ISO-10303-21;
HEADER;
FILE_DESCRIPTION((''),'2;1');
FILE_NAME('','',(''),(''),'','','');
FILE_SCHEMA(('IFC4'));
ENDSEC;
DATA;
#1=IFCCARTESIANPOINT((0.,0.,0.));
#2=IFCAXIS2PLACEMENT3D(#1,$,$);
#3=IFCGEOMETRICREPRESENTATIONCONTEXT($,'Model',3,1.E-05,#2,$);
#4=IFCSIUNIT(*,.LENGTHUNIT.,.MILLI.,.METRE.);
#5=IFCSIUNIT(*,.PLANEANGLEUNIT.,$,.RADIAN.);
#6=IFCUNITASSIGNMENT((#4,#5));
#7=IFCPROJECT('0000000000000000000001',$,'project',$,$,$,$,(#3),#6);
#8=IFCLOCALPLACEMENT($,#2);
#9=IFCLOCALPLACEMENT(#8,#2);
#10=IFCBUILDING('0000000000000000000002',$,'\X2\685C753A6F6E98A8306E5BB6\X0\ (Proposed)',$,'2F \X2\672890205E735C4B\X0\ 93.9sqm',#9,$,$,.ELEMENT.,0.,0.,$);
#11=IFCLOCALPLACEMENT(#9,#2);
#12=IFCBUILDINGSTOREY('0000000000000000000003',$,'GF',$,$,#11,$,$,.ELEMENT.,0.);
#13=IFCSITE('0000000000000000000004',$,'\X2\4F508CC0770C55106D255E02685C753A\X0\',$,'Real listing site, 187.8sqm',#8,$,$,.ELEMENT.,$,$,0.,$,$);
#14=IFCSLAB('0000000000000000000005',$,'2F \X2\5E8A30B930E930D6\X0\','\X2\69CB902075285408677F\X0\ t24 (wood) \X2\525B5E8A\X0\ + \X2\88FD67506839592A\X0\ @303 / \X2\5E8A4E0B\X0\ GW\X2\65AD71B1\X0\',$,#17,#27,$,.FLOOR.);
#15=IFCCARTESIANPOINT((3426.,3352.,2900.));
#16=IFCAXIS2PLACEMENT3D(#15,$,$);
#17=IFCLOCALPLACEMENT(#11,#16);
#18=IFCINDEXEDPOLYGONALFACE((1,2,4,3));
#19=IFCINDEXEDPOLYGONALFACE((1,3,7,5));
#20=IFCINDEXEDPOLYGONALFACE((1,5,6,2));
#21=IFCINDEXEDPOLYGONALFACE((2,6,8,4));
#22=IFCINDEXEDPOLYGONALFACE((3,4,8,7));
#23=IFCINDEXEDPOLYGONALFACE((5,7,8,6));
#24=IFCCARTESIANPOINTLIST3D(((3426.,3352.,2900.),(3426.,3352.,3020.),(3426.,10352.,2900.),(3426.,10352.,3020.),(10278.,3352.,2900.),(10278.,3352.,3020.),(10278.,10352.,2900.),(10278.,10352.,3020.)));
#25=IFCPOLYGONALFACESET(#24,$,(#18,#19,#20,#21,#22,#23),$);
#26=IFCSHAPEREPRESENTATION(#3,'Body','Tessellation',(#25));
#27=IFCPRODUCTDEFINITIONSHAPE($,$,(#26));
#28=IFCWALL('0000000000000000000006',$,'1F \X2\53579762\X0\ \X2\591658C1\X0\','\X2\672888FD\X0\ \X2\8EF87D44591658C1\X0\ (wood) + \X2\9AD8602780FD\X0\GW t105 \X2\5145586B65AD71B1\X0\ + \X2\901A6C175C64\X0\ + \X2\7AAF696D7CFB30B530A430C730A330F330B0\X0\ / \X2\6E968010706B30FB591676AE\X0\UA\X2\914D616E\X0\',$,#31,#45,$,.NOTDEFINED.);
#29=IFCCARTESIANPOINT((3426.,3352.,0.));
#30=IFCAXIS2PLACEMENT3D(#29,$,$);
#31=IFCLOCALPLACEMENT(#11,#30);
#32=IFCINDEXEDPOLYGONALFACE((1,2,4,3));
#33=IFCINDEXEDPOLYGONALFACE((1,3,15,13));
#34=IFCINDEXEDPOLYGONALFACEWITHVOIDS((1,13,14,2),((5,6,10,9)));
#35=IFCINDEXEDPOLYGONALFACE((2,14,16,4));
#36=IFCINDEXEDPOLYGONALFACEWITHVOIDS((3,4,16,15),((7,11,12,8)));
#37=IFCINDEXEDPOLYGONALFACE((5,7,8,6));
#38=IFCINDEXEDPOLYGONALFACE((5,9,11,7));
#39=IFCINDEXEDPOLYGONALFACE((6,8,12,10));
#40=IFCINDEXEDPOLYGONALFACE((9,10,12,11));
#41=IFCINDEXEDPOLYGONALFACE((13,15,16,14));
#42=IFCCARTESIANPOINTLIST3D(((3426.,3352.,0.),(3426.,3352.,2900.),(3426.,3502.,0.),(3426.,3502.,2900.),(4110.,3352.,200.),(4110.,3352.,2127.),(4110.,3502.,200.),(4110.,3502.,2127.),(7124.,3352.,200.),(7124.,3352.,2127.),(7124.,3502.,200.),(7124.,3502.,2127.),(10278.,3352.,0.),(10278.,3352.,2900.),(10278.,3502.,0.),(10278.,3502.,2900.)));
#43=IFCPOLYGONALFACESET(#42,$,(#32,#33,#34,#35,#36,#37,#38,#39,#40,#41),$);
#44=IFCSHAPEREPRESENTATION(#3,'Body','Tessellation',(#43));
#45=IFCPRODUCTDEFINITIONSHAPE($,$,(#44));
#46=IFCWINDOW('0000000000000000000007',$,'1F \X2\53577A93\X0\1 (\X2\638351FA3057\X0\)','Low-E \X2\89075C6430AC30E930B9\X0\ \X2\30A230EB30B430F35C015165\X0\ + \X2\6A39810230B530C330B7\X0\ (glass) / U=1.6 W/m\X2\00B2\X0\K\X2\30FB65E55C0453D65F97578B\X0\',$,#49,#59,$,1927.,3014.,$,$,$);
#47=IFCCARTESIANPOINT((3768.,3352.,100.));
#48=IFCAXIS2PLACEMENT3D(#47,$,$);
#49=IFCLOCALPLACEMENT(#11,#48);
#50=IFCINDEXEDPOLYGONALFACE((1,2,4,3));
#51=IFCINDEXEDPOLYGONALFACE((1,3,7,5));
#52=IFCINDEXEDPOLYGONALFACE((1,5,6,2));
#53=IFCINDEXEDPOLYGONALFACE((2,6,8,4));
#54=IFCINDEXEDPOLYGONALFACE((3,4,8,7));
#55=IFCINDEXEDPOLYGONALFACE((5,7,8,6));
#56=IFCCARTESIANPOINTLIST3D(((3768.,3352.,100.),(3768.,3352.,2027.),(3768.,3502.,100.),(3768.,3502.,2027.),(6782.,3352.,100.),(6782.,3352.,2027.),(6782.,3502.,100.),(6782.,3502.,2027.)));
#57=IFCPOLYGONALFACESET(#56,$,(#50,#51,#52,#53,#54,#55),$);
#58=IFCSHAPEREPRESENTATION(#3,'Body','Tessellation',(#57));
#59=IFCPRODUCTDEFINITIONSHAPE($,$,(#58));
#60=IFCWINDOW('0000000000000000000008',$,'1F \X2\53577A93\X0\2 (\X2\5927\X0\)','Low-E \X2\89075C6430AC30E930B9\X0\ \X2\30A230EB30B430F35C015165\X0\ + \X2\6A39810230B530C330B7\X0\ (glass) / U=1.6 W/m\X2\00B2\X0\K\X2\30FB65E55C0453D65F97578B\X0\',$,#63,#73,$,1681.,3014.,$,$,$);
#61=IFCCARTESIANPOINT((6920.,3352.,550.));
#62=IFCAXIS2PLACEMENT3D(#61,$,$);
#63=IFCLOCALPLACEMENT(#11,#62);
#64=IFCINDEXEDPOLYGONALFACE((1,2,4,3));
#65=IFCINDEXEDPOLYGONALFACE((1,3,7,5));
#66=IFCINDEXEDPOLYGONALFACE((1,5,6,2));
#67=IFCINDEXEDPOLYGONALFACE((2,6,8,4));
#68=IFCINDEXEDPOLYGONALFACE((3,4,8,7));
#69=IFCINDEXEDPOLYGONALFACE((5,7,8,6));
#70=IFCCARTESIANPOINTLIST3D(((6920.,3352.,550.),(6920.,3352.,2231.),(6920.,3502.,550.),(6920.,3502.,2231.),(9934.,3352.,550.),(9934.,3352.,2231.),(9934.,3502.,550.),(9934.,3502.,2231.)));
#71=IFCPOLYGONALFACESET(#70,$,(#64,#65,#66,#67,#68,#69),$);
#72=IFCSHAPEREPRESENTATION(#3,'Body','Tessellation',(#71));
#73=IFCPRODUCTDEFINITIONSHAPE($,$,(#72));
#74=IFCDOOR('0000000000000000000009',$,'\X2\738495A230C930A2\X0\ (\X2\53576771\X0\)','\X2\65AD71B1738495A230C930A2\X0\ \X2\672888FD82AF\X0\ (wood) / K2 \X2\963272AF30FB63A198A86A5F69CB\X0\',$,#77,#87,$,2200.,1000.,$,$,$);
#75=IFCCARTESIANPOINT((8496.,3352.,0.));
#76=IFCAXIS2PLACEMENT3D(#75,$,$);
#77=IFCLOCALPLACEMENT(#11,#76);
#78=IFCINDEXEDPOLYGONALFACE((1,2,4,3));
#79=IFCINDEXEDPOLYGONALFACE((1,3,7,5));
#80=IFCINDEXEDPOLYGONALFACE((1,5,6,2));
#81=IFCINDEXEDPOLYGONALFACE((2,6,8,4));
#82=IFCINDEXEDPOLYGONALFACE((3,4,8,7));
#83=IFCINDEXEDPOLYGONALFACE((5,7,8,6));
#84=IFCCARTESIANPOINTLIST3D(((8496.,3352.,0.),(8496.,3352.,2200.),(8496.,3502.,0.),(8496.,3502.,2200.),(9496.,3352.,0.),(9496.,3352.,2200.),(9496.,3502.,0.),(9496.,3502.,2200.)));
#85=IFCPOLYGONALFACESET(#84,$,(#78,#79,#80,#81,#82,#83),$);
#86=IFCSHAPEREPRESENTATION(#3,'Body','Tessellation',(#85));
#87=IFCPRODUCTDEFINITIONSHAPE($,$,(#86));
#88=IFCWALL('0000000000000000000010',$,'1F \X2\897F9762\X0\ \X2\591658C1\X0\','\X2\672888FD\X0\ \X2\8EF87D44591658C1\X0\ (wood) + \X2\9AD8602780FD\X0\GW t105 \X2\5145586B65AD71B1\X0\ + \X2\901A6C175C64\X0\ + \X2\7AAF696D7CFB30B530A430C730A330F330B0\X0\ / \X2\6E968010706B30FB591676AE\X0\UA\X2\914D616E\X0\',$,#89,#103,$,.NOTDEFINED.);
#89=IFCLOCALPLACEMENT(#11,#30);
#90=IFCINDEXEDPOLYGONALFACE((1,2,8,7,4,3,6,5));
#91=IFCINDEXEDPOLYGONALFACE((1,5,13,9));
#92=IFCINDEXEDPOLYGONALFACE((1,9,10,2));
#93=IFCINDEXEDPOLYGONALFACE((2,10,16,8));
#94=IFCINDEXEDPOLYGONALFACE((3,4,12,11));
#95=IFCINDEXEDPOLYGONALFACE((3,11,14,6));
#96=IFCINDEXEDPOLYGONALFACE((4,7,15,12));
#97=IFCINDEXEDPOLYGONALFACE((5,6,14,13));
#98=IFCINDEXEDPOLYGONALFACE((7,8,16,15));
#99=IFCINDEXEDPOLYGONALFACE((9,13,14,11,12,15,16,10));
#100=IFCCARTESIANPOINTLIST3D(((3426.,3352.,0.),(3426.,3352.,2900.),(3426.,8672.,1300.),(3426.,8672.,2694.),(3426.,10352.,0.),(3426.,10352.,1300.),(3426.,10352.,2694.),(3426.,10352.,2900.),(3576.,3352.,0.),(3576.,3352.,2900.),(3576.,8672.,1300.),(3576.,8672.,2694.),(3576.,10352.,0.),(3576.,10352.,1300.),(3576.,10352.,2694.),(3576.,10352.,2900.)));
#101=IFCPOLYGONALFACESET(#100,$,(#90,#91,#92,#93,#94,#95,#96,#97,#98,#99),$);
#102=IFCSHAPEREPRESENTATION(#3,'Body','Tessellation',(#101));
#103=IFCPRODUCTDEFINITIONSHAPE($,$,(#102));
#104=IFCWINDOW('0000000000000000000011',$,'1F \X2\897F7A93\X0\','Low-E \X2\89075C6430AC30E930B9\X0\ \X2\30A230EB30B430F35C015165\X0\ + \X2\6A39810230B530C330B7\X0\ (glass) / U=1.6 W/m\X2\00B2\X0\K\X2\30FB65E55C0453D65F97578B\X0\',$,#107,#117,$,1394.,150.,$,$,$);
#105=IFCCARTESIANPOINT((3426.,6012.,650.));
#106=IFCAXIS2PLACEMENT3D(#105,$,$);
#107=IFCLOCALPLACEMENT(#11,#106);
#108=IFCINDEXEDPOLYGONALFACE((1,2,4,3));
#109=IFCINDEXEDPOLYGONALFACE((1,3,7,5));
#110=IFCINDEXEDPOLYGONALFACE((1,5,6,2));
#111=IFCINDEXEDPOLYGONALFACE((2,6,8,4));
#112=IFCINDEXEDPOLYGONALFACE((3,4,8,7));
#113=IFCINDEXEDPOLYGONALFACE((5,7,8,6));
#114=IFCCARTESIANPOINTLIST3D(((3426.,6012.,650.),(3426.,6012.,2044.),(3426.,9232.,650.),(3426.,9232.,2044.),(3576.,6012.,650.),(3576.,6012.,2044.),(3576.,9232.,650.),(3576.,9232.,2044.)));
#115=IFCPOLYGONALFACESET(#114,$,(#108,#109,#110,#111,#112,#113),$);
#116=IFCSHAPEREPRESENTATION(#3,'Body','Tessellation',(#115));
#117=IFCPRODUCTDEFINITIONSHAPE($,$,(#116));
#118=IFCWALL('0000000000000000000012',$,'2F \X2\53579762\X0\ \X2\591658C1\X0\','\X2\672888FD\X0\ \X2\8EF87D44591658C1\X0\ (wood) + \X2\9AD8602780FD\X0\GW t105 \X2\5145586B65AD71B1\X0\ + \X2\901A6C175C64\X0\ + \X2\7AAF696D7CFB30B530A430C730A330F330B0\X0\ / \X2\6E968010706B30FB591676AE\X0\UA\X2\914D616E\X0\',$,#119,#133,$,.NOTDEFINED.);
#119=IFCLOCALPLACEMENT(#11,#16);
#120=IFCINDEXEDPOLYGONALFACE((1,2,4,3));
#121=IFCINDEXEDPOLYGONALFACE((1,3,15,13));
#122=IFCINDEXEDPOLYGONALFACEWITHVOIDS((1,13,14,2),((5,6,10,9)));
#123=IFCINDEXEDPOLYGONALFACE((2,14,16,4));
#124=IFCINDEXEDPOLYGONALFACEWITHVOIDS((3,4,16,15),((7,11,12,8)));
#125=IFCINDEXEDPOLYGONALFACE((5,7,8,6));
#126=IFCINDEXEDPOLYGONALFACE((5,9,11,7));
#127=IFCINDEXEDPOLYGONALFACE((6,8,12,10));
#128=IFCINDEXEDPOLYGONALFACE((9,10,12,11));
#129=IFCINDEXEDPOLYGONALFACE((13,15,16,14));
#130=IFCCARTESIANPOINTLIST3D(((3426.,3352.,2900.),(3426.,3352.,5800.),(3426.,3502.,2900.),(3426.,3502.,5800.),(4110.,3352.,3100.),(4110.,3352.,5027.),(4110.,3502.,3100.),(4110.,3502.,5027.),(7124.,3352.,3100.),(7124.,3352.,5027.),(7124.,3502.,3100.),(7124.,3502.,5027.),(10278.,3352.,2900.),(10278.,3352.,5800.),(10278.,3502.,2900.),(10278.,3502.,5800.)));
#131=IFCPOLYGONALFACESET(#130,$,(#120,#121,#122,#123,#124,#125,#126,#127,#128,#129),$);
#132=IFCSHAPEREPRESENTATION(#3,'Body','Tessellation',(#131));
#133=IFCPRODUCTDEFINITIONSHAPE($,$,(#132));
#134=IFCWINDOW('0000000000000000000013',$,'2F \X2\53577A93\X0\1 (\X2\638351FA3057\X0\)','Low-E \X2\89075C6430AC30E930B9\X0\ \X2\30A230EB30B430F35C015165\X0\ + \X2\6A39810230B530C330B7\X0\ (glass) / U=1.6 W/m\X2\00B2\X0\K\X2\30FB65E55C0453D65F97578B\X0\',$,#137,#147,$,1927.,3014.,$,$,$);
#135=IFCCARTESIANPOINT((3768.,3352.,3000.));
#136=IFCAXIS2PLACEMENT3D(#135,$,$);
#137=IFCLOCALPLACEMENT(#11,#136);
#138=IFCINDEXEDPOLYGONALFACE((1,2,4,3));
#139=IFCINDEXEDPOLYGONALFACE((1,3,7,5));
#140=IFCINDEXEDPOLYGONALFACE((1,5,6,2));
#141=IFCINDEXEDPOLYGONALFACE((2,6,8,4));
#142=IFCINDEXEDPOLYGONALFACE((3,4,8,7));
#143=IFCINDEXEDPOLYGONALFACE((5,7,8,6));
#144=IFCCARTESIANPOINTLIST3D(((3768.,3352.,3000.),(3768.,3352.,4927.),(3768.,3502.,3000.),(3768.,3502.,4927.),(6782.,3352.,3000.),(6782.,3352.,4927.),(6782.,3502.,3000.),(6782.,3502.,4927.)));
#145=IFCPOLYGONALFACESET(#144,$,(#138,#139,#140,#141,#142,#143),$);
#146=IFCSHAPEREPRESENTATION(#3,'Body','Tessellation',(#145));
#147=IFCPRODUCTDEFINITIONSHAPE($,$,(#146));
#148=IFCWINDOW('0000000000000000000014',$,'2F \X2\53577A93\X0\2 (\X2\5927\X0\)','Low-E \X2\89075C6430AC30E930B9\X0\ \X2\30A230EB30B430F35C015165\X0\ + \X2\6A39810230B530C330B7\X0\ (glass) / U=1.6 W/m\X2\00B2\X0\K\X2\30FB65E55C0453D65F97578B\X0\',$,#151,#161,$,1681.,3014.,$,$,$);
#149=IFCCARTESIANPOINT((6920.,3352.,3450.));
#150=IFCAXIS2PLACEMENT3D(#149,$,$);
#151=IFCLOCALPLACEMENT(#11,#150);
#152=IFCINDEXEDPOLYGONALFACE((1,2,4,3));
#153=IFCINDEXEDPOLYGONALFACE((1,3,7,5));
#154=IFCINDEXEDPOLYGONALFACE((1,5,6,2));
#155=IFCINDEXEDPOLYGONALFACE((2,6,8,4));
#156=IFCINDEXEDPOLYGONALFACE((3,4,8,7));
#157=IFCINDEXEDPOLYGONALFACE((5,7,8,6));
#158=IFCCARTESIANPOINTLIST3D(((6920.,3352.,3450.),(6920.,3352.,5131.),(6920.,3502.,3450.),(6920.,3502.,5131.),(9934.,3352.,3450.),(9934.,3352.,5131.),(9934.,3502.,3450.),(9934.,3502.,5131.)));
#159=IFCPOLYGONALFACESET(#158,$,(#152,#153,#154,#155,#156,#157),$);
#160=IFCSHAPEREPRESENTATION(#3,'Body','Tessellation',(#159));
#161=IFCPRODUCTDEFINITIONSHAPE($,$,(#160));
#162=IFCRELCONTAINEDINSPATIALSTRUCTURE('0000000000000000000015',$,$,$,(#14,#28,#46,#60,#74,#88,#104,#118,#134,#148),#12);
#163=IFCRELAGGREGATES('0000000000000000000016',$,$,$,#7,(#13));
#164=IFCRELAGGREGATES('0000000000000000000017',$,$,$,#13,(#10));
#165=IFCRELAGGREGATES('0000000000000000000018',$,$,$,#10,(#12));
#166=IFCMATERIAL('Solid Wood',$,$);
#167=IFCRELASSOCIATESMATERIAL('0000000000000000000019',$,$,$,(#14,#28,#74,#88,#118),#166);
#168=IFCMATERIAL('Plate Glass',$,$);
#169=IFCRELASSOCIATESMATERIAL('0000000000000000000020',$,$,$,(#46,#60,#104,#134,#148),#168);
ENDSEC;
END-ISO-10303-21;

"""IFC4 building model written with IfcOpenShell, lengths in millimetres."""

from ifc_helpers import new_model, si_unit, frame, frame_2d, origin, place, context, project, spatial, rectangle, extrude, material, element, fill, save


model = new_model("IFC4")

# Units and contexts
model_context = context("Model", 3, precision=1e-05, world=origin())
ifc_project = project(units=[si_unit("LENGTHUNIT", "METRE", prefix="MILLI"), si_unit("PLANEANGLEUNIT", "RADIAN")], contexts=[model_context])

# Site, building, storey
site_placement = place(None, origin())
site = spatial("IfcSite", under=ifc_project, at=site_placement, Name="佐賀県唐津市桜町", ObjectType="Real listing site, 187.8sqm", CompositionType="ELEMENT", RefElevation=0.0)
building_placement = place(site_placement, origin())
building = spatial("IfcBuilding", under=site, at=building_placement, Name="桜町潮風の家 (Proposed)", ObjectType="2F 木造平屋 93.9sqm", CompositionType="ELEMENT", ElevationOfRefHeight=0.0, ElevationOfTerrain=0.0)
storey_placement = place(building_placement, origin())
storey = spatial("IfcBuildingStorey", under=building, at=storey_placement, Name="GF", CompositionType="ELEMENT", Elevation=0.0)

# Slab
ifc_material_1 = material(Name="Solid Wood")
slab_1_placement = place(storey_placement, frame((3426.0, 3352.0, 2900.0)))
element("IfcSlab", 1, at=slab_1_placement, inside=storey, material=ifc_material_1, Name="2F 床スラブ", Description="構造用合板 t24 (wood) 剛床 + 製材根太 @303 / 床下 GW断熱", PredefinedType="FLOOR", context=model_context, shape_type="SweptSolid", body=[
    extrude(rectangle(XDim=6852.0, YDim=7000.0, at=frame_2d((3426.0, 3500.0))), frame((3426.0, 3352.0, 2900.0)), (0.0, 0.0, 1.0), 120.0),
])

# Wall, openings, windows, door
wall_1_placement = place(storey_placement, frame((3426.0, 3352.0, 0.0)))
wall_1 = element("IfcWall", 2, at=wall_1_placement, inside=storey, material=ifc_material_1, Name="1F 南面 外壁", Description="木製 軸組外壁 (wood) + 高性能GW t105 充填断熱 + 通気層 + 窯業系サイディング / 準耐火・外皮UA配慮", PredefinedType="NOTDEFINED", context=model_context, shape_type="SweptSolid", body=[
    extrude(rectangle(XDim=6852.0, YDim=150.0, at=frame_2d((3426.0, 75.0))), frame((3426.0, 3352.0, 0.0)), (0.0, 0.0, 1.0), 2900.0),
])
opening_1_placement = place(storey_placement, frame((3768.0, 3352.0, 100.0)))
opening_1 = element("IfcOpeningElement", 3, at=opening_1_placement, cuts=wall_1, PredefinedType="NOTDEFINED", context=model_context, shape_type="SweptSolid", body=[
    extrude(rectangle(XDim=3014.0, YDim=150.0, at=frame_2d((1507.0, 75.0))), frame((3768.0, 3352.0, 100.0)), (0.0, 0.0, 1.0), 1927.0),
])
opening_2_placement = place(storey_placement, frame((6920.0, 3352.0, 550.0)))
opening_2 = element("IfcOpeningElement", 4, at=opening_2_placement, cuts=wall_1, PredefinedType="NOTDEFINED", context=model_context, shape_type="SweptSolid", body=[
    extrude(rectangle(XDim=3014.0, YDim=150.0, at=frame_2d((1507.0, 75.0))), frame((6920.0, 3352.0, 550.0)), (0.0, 0.0, 1.0), 1681.0),
])
opening_3_placement = place(storey_placement, frame((8496.0, 3352.0, 0.0)))
opening_3 = element("IfcOpeningElement", 5, at=opening_3_placement, cuts=wall_1, PredefinedType="NOTDEFINED", context=model_context, shape_type="SweptSolid", body=[
    extrude(rectangle(XDim=1000.0, YDim=150.0, at=frame_2d((500.0, 75.0))), frame((8496.0, 3352.0, 0.0)), (0.0, 0.0, 1.0), 2200.0),
])
ifc_material_2 = material(Name="Plate Glass")
window_1_placement = place(storey_placement, frame((3768.0, 3352.0, 100.0)))
window_1 = element("IfcWindow", 6, at=window_1_placement, inside=storey, material=ifc_material_2, Name="1F 南窓1 (掃出し)", Description="Low-E 複層ガラス アルゴン封入 + 樹脂サッシ (glass) / U=1.6 W/m²K・日射取得型", OverallHeight=1927.0, OverallWidth=3014.0, context=model_context, shape_type="SweptSolid", body=[
    extrude(rectangle(XDim=3014.0, YDim=150.0, at=frame_2d((1507.0, 75.0))), frame((3768.0, 3352.0, 100.0)), (0.0, 0.0, 1.0), 1927.0),
])
fill(opening_1, window_1)
window_2_placement = place(storey_placement, frame((6920.0, 3352.0, 550.0)))
window_2 = element("IfcWindow", 7, at=window_2_placement, inside=storey, material=ifc_material_2, Name="1F 南窓2 (大)", Description="Low-E 複層ガラス アルゴン封入 + 樹脂サッシ (glass) / U=1.6 W/m²K・日射取得型", OverallHeight=1681.0, OverallWidth=3014.0, context=model_context, shape_type="SweptSolid", body=[
    extrude(rectangle(XDim=3014.0, YDim=150.0, at=frame_2d((1507.0, 75.0))), frame((6920.0, 3352.0, 550.0)), (0.0, 0.0, 1.0), 1681.0),
])
fill(opening_2, window_2)
door_placement = place(storey_placement, frame((8496.0, 3352.0, 0.0)))
door = element("IfcDoor", 8, at=door_placement, inside=storey, material=ifc_material_1, Name="玄関ドア (南東)", Description="断熱玄関ドア 木製芯 (wood) / K2 防犯・採風機構", OverallHeight=2200.0, OverallWidth=1000.0, context=model_context, shape_type="SweptSolid", body=[
    extrude(rectangle(XDim=1000.0, YDim=150.0, at=frame_2d((500.0, 75.0))), frame((8496.0, 3352.0, 0.0)), (0.0, 0.0, 1.0), 2200.0),
])
fill(opening_3, door)

# Wall, opening, window
wall_2_placement = place(storey_placement, frame((3426.0, 3352.0, 0.0)))
wall_2 = element("IfcWall", 9, at=wall_2_placement, inside=storey, material=ifc_material_1, Name="1F 西面 外壁", Description="木製 軸組外壁 (wood) + 高性能GW t105 充填断熱 + 通気層 + 窯業系サイディング / 準耐火・外皮UA配慮", PredefinedType="NOTDEFINED", context=model_context, shape_type="SweptSolid", body=[
    extrude(rectangle(XDim=150.0, YDim=7000.0, at=frame_2d((75.0, 3500.0))), frame((3426.0, 3352.0, 0.0)), (0.0, 0.0, 1.0), 2900.0),
])
opening_4_placement = place(storey_placement, frame((3426.0, 6012.0, 650.0)))
opening_4 = element("IfcOpeningElement", 10, at=opening_4_placement, cuts=wall_2, PredefinedType="NOTDEFINED", context=model_context, shape_type="SweptSolid", body=[
    extrude(rectangle(XDim=150.0, YDim=3220.0, at=frame_2d((75.0, 1610.0))), frame((3426.0, 6012.0, 650.0)), (0.0, 0.0, 1.0), 1394.0),
])
window_3_placement = place(storey_placement, frame((3426.0, 6012.0, 650.0)))
window_3 = element("IfcWindow", 11, at=window_3_placement, inside=storey, material=ifc_material_2, Name="1F 西窓", Description="Low-E 複層ガラス アルゴン封入 + 樹脂サッシ (glass) / U=1.6 W/m²K・日射取得型", OverallHeight=1394.0, OverallWidth=150.0, context=model_context, shape_type="SweptSolid", body=[
    extrude(rectangle(XDim=150.0, YDim=3220.0, at=frame_2d((75.0, 1610.0))), frame((3426.0, 6012.0, 650.0)), (0.0, 0.0, 1.0), 1394.0),
])
fill(opening_4, window_3)

# Wall, openings, windows
wall_3_placement = place(storey_placement, frame((3426.0, 3352.0, 2900.0)))
wall_3 = element("IfcWall", 12, at=wall_3_placement, inside=storey, material=ifc_material_1, Name="2F 南面 外壁", Description="木製 軸組外壁 (wood) + 高性能GW t105 充填断熱 + 通気層 + 窯業系サイディング / 準耐火・外皮UA配慮", PredefinedType="NOTDEFINED", context=model_context, shape_type="SweptSolid", body=[
    extrude(rectangle(XDim=6852.0, YDim=150.0, at=frame_2d((3426.0, 75.0))), frame((3426.0, 3352.0, 2900.0)), (0.0, 0.0, 1.0), 2900.0),
])
opening_5_placement = place(storey_placement, frame((3768.0, 3352.0, 3000.0)))
opening_5 = element("IfcOpeningElement", 13, at=opening_5_placement, cuts=wall_3, PredefinedType="NOTDEFINED", context=model_context, shape_type="SweptSolid", body=[
    extrude(rectangle(XDim=3014.0, YDim=150.0, at=frame_2d((1507.0, 75.0))), frame((3768.0, 3352.0, 3000.0)), (0.0, 0.0, 1.0), 1927.0),
])
opening_6_placement = place(storey_placement, frame((6920.0, 3352.0, 3450.0)))
opening_6 = element("IfcOpeningElement", 14, at=opening_6_placement, cuts=wall_3, PredefinedType="NOTDEFINED", context=model_context, shape_type="SweptSolid", body=[
    extrude(rectangle(XDim=3014.0, YDim=150.0, at=frame_2d((1507.0, 75.0))), frame((6920.0, 3352.0, 3450.0)), (0.0, 0.0, 1.0), 1681.0),
])
window_4_placement = place(storey_placement, frame((3768.0, 3352.0, 3000.0)))
window_4 = element("IfcWindow", 15, at=window_4_placement, inside=storey, material=ifc_material_2, Name="2F 南窓1 (掃出し)", Description="Low-E 複層ガラス アルゴン封入 + 樹脂サッシ (glass) / U=1.6 W/m²K・日射取得型", OverallHeight=1927.0, OverallWidth=3014.0, context=model_context, shape_type="SweptSolid", body=[
    extrude(rectangle(XDim=3014.0, YDim=150.0, at=frame_2d((1507.0, 75.0))), frame((3768.0, 3352.0, 3000.0)), (0.0, 0.0, 1.0), 1927.0),
])
fill(opening_5, window_4)
window_5_placement = place(storey_placement, frame((6920.0, 3352.0, 3450.0)))
window_5 = element("IfcWindow", 16, at=window_5_placement, inside=storey, material=ifc_material_2, Name="2F 南窓2 (大)", Description="Low-E 複層ガラス アルゴン封入 + 樹脂サッシ (glass) / U=1.6 W/m²K・日射取得型", OverallHeight=1681.0, OverallWidth=3014.0, context=model_context, shape_type="SweptSolid", body=[
    extrude(rectangle(XDim=3014.0, YDim=150.0, at=frame_2d((1507.0, 75.0))), frame((6920.0, 3352.0, 3450.0)), (0.0, 0.0, 1.0), 1681.0),
])
fill(opening_6, window_5)

save(model, "model.ifc")
